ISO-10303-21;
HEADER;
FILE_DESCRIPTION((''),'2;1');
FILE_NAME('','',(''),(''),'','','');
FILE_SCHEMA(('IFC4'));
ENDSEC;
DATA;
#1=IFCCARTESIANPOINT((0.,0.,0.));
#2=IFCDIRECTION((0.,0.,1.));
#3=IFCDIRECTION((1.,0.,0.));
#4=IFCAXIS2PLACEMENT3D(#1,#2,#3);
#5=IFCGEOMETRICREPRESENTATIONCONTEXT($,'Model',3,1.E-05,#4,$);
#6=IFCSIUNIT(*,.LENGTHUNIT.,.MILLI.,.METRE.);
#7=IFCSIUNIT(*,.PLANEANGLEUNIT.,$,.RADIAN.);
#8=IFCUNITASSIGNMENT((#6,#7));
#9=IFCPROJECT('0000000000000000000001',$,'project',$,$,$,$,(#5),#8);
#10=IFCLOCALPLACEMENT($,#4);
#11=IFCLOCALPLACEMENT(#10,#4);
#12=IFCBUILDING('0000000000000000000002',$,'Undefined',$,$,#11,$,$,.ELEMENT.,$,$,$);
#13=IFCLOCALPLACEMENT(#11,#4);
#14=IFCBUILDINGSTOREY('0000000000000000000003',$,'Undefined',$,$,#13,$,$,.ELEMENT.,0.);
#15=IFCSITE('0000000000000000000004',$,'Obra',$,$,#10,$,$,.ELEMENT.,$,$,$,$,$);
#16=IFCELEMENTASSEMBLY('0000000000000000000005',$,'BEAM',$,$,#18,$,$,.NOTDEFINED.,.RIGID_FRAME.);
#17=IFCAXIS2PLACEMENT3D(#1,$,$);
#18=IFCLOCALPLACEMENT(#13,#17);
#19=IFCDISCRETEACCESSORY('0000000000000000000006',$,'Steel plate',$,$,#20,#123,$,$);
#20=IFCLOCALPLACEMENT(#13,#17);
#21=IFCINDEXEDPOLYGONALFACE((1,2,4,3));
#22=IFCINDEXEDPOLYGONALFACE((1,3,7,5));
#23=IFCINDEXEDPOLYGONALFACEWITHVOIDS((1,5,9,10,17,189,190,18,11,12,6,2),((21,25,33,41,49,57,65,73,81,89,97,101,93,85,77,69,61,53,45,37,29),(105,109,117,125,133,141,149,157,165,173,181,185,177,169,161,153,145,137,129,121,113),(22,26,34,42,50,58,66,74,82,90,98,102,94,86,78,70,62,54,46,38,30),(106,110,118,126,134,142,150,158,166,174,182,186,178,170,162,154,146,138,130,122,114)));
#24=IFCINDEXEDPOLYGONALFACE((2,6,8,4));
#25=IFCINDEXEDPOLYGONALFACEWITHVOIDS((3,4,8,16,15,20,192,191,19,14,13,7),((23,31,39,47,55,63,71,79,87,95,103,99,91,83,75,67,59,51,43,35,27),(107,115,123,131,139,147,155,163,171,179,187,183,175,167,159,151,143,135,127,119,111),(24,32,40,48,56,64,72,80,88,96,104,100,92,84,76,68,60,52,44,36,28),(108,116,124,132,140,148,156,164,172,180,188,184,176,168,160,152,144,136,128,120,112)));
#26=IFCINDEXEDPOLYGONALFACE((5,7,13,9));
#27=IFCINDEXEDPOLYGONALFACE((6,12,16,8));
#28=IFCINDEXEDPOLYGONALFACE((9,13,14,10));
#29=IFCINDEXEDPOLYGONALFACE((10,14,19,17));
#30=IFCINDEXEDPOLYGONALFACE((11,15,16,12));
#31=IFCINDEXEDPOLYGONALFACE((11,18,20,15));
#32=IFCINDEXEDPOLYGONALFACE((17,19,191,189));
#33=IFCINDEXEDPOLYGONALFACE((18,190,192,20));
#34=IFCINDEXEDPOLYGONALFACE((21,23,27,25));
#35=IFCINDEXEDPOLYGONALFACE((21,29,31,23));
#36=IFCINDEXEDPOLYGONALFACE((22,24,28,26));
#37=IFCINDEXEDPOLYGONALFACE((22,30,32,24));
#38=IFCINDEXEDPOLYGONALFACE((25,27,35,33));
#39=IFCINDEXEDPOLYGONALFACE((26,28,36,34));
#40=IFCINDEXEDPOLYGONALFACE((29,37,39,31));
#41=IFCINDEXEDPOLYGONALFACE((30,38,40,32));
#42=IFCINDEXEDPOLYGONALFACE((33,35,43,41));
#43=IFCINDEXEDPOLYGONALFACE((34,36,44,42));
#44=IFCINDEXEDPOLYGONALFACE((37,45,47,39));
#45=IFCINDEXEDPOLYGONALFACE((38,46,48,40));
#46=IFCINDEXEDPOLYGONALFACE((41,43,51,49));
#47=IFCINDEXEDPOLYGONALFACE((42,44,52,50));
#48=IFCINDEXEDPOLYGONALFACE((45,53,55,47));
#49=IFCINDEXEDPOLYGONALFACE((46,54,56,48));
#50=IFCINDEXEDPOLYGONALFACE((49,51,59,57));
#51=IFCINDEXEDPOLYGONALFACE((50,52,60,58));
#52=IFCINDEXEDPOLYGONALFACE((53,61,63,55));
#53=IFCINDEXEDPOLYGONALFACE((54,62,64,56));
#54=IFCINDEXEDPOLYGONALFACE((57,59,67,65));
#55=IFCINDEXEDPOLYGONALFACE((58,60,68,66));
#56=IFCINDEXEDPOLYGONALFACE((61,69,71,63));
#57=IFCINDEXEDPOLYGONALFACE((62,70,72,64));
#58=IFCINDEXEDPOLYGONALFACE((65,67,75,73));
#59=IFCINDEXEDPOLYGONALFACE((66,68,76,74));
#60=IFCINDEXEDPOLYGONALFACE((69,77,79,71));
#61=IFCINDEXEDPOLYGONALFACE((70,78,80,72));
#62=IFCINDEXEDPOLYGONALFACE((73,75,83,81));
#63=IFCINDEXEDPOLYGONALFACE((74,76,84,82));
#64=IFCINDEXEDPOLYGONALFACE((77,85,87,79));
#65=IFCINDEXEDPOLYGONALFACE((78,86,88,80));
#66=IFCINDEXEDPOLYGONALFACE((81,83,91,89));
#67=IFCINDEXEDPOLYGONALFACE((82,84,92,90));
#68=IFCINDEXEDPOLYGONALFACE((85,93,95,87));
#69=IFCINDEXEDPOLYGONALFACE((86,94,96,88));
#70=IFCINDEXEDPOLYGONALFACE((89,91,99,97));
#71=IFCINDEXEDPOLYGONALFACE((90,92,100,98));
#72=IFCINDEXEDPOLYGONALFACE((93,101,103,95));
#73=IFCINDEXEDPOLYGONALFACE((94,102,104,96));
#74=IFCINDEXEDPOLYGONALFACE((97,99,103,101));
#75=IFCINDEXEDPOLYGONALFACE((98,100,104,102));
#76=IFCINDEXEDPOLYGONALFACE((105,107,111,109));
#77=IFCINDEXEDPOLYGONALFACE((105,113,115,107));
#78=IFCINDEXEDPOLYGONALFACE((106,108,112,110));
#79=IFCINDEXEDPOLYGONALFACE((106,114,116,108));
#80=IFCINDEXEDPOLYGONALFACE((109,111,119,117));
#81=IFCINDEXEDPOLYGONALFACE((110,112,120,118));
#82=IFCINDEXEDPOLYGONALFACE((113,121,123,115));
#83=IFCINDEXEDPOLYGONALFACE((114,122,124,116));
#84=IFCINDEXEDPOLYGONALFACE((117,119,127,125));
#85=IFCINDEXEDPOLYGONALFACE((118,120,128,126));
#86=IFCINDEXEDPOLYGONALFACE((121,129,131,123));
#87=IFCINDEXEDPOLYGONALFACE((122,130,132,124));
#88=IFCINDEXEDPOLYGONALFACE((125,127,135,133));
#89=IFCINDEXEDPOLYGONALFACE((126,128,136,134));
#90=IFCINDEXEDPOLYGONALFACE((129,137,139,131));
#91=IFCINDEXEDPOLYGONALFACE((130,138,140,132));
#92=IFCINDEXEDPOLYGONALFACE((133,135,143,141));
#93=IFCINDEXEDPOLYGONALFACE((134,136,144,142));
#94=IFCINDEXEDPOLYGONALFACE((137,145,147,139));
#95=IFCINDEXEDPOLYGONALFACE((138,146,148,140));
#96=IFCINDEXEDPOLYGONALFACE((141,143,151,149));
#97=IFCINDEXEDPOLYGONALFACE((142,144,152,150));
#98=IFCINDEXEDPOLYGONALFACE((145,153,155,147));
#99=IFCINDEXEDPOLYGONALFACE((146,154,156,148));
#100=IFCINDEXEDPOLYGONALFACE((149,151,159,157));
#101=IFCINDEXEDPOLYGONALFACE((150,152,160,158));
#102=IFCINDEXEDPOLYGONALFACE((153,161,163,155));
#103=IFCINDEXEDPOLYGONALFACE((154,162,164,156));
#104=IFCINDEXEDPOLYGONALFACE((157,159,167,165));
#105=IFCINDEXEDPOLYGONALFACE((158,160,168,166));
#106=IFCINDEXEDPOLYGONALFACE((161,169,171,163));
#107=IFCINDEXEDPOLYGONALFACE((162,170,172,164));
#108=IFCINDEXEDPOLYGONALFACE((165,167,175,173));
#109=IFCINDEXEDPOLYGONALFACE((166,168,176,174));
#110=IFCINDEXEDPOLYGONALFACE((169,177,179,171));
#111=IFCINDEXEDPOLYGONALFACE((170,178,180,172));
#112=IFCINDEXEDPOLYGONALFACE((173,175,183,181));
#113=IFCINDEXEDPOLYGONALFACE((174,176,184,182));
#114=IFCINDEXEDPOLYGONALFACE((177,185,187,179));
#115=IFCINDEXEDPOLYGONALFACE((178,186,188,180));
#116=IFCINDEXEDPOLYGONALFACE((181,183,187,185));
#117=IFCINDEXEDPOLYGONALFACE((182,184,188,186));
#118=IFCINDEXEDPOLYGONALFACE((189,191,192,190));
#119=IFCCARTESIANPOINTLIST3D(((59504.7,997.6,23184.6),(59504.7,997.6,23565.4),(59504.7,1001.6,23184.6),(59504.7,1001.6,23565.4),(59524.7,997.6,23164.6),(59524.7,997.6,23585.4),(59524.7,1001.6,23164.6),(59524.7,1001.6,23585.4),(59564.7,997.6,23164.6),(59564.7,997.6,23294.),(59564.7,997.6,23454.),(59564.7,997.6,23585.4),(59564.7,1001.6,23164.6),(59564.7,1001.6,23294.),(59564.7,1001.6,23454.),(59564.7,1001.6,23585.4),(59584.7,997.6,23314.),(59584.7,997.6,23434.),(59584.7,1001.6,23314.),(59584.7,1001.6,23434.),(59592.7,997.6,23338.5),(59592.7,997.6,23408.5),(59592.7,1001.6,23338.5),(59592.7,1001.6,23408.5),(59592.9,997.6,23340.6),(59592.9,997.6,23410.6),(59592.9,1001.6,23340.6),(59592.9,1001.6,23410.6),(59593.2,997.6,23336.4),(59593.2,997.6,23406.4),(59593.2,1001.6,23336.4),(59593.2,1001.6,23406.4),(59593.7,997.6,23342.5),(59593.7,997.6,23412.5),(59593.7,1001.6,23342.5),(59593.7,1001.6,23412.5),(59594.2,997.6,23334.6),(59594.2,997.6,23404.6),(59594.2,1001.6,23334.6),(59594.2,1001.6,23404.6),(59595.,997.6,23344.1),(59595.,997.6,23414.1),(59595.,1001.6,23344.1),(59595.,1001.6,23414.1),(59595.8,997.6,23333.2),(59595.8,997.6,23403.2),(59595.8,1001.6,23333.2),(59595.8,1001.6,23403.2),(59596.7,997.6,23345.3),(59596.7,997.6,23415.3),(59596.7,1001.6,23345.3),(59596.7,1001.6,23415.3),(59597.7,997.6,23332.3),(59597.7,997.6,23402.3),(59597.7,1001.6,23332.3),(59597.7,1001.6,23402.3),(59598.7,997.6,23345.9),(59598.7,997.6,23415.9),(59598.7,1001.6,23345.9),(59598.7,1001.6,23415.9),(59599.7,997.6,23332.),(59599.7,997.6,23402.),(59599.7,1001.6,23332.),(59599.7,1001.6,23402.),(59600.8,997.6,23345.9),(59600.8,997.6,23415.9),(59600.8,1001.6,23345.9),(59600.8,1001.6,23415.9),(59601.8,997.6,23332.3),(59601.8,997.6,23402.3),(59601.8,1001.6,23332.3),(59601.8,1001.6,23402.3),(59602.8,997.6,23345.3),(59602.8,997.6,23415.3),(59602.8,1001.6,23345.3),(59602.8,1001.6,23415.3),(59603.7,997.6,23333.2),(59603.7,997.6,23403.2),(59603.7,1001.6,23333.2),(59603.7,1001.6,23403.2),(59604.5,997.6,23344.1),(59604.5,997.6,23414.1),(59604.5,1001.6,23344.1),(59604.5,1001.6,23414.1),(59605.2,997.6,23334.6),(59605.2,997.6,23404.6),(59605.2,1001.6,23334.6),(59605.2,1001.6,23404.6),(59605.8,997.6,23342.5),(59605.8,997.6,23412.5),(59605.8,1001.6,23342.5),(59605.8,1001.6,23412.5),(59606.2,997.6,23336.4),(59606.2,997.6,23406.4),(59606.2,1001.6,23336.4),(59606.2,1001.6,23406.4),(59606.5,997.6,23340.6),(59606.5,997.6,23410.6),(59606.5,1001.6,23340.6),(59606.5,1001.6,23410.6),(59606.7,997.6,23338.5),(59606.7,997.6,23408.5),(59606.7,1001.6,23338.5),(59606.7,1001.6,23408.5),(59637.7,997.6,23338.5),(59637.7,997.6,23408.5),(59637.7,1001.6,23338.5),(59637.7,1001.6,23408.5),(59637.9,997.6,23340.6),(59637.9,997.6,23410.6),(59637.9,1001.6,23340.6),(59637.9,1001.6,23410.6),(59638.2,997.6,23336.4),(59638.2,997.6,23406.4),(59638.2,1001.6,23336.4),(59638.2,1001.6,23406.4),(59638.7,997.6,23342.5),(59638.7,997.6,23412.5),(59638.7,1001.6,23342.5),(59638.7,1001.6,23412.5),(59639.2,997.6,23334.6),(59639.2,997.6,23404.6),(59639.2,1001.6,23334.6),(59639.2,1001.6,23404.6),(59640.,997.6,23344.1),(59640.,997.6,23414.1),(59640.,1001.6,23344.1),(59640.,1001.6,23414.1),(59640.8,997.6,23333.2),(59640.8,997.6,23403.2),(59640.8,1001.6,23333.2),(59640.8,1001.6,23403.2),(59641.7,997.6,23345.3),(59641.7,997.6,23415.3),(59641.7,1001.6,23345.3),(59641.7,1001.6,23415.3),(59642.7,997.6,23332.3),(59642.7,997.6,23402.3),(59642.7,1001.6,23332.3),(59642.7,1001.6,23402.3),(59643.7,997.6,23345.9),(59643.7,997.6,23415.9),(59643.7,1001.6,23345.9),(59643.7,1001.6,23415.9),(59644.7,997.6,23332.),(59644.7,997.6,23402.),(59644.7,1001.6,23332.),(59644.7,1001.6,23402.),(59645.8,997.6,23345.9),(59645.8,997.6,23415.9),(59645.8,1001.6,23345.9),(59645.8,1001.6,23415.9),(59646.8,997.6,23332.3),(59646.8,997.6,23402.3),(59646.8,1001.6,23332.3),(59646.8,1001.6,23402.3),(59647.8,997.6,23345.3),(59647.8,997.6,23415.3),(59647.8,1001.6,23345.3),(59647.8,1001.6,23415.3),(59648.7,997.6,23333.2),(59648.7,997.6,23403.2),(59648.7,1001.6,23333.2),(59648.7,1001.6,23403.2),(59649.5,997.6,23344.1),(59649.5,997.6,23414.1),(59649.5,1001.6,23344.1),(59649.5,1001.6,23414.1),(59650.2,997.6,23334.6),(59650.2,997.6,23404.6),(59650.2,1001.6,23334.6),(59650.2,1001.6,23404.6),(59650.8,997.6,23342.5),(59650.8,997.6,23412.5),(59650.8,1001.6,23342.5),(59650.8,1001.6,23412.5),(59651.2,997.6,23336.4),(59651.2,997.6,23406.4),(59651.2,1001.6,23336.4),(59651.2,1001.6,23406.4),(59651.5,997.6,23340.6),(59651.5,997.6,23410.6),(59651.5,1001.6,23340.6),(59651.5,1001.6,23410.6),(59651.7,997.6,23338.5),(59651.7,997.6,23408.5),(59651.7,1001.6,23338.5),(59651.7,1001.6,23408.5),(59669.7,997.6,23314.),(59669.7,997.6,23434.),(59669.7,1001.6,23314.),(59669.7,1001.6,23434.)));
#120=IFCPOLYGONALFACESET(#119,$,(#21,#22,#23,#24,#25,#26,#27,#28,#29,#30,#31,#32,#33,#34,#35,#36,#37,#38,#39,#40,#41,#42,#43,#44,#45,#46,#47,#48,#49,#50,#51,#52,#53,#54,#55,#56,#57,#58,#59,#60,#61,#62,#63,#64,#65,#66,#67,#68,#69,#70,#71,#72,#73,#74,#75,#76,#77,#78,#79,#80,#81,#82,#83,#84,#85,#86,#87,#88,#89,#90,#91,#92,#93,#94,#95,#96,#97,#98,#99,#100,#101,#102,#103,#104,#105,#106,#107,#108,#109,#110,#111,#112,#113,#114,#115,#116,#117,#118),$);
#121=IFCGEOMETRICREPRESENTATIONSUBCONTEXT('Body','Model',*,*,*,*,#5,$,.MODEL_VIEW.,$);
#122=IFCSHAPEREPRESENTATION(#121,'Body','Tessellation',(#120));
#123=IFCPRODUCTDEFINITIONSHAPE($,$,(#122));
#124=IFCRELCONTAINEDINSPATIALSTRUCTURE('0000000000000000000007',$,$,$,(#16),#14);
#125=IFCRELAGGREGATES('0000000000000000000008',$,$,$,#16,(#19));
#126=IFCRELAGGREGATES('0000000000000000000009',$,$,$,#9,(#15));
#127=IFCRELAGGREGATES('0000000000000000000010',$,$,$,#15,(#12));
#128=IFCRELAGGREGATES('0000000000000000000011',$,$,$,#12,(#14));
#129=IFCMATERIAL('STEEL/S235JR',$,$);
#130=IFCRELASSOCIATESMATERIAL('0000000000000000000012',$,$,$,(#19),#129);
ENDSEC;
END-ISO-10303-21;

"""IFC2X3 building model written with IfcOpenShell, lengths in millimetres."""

from ifc_helpers import new_model, si_unit, frame, origin_with_axes, origin_2d_with_axis, place, context, subcontext, project, spatial, polyline, circle, outline, extrude, source, transform, mapped, material, element, aggregate, save


model = new_model("IFC2X3")

# Units and contexts
model_context = context("Model", 3, precision=1e-05, world=origin_with_axes())
body_context = subcontext(model_context, "Body", "Model", "MODEL_VIEW")
ifc_project = project(units=[si_unit("LENGTHUNIT", "METRE", prefix="MILLI"), si_unit("PLANEANGLEUNIT", "RADIAN")], contexts=[model_context])

# Site, building, storey
site_placement = place(None, origin_with_axes())
site = spatial("IfcSite", under=ifc_project, at=site_placement, Name="Obra", CompositionType="ELEMENT")
building_placement = place(site_placement, origin_with_axes())
building = spatial("IfcBuilding", under=site, at=building_placement, Name="Undefined", CompositionType="ELEMENT")
storey_placement = place(building_placement, origin_with_axes())
storey = spatial("IfcBuildingStorey", under=building, at=storey_placement, Name="Undefined", CompositionType="ELEMENT", Elevation=0.0)

# Element assembly
assembly_1_placement = place(storey_placement, origin_with_axes())
assembly_1 = element("IfcElementAssembly", 1, at=assembly_1_placement, inside=storey, Name="BEAM", AssemblyPlace="NOTDEFINED", PredefinedType="RIGID_FRAME")
ifc_material_1 = material(Name="STEEL/S235JR")

# Discrete accessory, opening
discrete_accessory_1_placement = place(assembly_1_placement, frame((59504.7, 999.6, 23184.6), z_axis=(-0.000014, -1.0, 0.0), x_axis=(0.707107, -0.00001, -0.707107)))
discrete_accessory_1 = element("IfcDiscreteAccessory", 2, at=discrete_accessory_1_placement, material=ifc_material_1, Name="Steel plate", context=body_context, shape_type="SweptSolid", body=[
    extrude(outline(polyline([(0.0, 0.0), (28.3, 0.0), (56.6, 28.3), (-34.9, 119.8), (-34.9, 148.1), (25.2, 208.2), (-59.7, 293.0), (-119.8, 232.9), (-148.1, 232.9), (-241.0, 325.8), (-269.3, 297.6), (-269.3, 269.3), (0.0, 0.0)])), frame((0.0, 0.0, -2.0), z_axis=(0.0, 0.0, 1.0), x_axis=(1.0, 0.0, 0.0)), (0.0, 0.0, 1.0), 4.0),
])
shared_shape_1 = source(origin_with_axes(), body_context, "Body", "SweptSolid", [
    extrude(circle(Radius=7.0, at=origin_2d_with_axis()), frame((0.0, -36.6, 0.0), z_axis=(0.0, 1.0, 0.0), x_axis=(1.0, 0.0, 0.0)), (0.0, 0.0, 1.0), 4.2),
])
opening_1_placement = place(assembly_1_placement, frame((59574.7, 1034.1, 23434.0), z_axis=(1.0, -0.000014, 0.0), x_axis=(0.0, 0.0, -1.0)))
element("IfcOpeningElement", 3, at=opening_1_placement, cuts=discrete_accessory_1, ObjectType="Opening", context=body_context, shape_type="MappedRepresentation", body=[
    mapped(shared_shape_1, transform((25.0, 0.0, 25.0))),
    mapped(shared_shape_1, transform((25.0, 0.0, 70.0))),
    mapped(shared_shape_1, transform((95.0, 0.0, 25.0))),
    mapped(shared_shape_1, transform((95.0, 0.0, 70.0))),
])
aggregate(assembly_1, [discrete_accessory_1])

save(model, "model.ifc")
